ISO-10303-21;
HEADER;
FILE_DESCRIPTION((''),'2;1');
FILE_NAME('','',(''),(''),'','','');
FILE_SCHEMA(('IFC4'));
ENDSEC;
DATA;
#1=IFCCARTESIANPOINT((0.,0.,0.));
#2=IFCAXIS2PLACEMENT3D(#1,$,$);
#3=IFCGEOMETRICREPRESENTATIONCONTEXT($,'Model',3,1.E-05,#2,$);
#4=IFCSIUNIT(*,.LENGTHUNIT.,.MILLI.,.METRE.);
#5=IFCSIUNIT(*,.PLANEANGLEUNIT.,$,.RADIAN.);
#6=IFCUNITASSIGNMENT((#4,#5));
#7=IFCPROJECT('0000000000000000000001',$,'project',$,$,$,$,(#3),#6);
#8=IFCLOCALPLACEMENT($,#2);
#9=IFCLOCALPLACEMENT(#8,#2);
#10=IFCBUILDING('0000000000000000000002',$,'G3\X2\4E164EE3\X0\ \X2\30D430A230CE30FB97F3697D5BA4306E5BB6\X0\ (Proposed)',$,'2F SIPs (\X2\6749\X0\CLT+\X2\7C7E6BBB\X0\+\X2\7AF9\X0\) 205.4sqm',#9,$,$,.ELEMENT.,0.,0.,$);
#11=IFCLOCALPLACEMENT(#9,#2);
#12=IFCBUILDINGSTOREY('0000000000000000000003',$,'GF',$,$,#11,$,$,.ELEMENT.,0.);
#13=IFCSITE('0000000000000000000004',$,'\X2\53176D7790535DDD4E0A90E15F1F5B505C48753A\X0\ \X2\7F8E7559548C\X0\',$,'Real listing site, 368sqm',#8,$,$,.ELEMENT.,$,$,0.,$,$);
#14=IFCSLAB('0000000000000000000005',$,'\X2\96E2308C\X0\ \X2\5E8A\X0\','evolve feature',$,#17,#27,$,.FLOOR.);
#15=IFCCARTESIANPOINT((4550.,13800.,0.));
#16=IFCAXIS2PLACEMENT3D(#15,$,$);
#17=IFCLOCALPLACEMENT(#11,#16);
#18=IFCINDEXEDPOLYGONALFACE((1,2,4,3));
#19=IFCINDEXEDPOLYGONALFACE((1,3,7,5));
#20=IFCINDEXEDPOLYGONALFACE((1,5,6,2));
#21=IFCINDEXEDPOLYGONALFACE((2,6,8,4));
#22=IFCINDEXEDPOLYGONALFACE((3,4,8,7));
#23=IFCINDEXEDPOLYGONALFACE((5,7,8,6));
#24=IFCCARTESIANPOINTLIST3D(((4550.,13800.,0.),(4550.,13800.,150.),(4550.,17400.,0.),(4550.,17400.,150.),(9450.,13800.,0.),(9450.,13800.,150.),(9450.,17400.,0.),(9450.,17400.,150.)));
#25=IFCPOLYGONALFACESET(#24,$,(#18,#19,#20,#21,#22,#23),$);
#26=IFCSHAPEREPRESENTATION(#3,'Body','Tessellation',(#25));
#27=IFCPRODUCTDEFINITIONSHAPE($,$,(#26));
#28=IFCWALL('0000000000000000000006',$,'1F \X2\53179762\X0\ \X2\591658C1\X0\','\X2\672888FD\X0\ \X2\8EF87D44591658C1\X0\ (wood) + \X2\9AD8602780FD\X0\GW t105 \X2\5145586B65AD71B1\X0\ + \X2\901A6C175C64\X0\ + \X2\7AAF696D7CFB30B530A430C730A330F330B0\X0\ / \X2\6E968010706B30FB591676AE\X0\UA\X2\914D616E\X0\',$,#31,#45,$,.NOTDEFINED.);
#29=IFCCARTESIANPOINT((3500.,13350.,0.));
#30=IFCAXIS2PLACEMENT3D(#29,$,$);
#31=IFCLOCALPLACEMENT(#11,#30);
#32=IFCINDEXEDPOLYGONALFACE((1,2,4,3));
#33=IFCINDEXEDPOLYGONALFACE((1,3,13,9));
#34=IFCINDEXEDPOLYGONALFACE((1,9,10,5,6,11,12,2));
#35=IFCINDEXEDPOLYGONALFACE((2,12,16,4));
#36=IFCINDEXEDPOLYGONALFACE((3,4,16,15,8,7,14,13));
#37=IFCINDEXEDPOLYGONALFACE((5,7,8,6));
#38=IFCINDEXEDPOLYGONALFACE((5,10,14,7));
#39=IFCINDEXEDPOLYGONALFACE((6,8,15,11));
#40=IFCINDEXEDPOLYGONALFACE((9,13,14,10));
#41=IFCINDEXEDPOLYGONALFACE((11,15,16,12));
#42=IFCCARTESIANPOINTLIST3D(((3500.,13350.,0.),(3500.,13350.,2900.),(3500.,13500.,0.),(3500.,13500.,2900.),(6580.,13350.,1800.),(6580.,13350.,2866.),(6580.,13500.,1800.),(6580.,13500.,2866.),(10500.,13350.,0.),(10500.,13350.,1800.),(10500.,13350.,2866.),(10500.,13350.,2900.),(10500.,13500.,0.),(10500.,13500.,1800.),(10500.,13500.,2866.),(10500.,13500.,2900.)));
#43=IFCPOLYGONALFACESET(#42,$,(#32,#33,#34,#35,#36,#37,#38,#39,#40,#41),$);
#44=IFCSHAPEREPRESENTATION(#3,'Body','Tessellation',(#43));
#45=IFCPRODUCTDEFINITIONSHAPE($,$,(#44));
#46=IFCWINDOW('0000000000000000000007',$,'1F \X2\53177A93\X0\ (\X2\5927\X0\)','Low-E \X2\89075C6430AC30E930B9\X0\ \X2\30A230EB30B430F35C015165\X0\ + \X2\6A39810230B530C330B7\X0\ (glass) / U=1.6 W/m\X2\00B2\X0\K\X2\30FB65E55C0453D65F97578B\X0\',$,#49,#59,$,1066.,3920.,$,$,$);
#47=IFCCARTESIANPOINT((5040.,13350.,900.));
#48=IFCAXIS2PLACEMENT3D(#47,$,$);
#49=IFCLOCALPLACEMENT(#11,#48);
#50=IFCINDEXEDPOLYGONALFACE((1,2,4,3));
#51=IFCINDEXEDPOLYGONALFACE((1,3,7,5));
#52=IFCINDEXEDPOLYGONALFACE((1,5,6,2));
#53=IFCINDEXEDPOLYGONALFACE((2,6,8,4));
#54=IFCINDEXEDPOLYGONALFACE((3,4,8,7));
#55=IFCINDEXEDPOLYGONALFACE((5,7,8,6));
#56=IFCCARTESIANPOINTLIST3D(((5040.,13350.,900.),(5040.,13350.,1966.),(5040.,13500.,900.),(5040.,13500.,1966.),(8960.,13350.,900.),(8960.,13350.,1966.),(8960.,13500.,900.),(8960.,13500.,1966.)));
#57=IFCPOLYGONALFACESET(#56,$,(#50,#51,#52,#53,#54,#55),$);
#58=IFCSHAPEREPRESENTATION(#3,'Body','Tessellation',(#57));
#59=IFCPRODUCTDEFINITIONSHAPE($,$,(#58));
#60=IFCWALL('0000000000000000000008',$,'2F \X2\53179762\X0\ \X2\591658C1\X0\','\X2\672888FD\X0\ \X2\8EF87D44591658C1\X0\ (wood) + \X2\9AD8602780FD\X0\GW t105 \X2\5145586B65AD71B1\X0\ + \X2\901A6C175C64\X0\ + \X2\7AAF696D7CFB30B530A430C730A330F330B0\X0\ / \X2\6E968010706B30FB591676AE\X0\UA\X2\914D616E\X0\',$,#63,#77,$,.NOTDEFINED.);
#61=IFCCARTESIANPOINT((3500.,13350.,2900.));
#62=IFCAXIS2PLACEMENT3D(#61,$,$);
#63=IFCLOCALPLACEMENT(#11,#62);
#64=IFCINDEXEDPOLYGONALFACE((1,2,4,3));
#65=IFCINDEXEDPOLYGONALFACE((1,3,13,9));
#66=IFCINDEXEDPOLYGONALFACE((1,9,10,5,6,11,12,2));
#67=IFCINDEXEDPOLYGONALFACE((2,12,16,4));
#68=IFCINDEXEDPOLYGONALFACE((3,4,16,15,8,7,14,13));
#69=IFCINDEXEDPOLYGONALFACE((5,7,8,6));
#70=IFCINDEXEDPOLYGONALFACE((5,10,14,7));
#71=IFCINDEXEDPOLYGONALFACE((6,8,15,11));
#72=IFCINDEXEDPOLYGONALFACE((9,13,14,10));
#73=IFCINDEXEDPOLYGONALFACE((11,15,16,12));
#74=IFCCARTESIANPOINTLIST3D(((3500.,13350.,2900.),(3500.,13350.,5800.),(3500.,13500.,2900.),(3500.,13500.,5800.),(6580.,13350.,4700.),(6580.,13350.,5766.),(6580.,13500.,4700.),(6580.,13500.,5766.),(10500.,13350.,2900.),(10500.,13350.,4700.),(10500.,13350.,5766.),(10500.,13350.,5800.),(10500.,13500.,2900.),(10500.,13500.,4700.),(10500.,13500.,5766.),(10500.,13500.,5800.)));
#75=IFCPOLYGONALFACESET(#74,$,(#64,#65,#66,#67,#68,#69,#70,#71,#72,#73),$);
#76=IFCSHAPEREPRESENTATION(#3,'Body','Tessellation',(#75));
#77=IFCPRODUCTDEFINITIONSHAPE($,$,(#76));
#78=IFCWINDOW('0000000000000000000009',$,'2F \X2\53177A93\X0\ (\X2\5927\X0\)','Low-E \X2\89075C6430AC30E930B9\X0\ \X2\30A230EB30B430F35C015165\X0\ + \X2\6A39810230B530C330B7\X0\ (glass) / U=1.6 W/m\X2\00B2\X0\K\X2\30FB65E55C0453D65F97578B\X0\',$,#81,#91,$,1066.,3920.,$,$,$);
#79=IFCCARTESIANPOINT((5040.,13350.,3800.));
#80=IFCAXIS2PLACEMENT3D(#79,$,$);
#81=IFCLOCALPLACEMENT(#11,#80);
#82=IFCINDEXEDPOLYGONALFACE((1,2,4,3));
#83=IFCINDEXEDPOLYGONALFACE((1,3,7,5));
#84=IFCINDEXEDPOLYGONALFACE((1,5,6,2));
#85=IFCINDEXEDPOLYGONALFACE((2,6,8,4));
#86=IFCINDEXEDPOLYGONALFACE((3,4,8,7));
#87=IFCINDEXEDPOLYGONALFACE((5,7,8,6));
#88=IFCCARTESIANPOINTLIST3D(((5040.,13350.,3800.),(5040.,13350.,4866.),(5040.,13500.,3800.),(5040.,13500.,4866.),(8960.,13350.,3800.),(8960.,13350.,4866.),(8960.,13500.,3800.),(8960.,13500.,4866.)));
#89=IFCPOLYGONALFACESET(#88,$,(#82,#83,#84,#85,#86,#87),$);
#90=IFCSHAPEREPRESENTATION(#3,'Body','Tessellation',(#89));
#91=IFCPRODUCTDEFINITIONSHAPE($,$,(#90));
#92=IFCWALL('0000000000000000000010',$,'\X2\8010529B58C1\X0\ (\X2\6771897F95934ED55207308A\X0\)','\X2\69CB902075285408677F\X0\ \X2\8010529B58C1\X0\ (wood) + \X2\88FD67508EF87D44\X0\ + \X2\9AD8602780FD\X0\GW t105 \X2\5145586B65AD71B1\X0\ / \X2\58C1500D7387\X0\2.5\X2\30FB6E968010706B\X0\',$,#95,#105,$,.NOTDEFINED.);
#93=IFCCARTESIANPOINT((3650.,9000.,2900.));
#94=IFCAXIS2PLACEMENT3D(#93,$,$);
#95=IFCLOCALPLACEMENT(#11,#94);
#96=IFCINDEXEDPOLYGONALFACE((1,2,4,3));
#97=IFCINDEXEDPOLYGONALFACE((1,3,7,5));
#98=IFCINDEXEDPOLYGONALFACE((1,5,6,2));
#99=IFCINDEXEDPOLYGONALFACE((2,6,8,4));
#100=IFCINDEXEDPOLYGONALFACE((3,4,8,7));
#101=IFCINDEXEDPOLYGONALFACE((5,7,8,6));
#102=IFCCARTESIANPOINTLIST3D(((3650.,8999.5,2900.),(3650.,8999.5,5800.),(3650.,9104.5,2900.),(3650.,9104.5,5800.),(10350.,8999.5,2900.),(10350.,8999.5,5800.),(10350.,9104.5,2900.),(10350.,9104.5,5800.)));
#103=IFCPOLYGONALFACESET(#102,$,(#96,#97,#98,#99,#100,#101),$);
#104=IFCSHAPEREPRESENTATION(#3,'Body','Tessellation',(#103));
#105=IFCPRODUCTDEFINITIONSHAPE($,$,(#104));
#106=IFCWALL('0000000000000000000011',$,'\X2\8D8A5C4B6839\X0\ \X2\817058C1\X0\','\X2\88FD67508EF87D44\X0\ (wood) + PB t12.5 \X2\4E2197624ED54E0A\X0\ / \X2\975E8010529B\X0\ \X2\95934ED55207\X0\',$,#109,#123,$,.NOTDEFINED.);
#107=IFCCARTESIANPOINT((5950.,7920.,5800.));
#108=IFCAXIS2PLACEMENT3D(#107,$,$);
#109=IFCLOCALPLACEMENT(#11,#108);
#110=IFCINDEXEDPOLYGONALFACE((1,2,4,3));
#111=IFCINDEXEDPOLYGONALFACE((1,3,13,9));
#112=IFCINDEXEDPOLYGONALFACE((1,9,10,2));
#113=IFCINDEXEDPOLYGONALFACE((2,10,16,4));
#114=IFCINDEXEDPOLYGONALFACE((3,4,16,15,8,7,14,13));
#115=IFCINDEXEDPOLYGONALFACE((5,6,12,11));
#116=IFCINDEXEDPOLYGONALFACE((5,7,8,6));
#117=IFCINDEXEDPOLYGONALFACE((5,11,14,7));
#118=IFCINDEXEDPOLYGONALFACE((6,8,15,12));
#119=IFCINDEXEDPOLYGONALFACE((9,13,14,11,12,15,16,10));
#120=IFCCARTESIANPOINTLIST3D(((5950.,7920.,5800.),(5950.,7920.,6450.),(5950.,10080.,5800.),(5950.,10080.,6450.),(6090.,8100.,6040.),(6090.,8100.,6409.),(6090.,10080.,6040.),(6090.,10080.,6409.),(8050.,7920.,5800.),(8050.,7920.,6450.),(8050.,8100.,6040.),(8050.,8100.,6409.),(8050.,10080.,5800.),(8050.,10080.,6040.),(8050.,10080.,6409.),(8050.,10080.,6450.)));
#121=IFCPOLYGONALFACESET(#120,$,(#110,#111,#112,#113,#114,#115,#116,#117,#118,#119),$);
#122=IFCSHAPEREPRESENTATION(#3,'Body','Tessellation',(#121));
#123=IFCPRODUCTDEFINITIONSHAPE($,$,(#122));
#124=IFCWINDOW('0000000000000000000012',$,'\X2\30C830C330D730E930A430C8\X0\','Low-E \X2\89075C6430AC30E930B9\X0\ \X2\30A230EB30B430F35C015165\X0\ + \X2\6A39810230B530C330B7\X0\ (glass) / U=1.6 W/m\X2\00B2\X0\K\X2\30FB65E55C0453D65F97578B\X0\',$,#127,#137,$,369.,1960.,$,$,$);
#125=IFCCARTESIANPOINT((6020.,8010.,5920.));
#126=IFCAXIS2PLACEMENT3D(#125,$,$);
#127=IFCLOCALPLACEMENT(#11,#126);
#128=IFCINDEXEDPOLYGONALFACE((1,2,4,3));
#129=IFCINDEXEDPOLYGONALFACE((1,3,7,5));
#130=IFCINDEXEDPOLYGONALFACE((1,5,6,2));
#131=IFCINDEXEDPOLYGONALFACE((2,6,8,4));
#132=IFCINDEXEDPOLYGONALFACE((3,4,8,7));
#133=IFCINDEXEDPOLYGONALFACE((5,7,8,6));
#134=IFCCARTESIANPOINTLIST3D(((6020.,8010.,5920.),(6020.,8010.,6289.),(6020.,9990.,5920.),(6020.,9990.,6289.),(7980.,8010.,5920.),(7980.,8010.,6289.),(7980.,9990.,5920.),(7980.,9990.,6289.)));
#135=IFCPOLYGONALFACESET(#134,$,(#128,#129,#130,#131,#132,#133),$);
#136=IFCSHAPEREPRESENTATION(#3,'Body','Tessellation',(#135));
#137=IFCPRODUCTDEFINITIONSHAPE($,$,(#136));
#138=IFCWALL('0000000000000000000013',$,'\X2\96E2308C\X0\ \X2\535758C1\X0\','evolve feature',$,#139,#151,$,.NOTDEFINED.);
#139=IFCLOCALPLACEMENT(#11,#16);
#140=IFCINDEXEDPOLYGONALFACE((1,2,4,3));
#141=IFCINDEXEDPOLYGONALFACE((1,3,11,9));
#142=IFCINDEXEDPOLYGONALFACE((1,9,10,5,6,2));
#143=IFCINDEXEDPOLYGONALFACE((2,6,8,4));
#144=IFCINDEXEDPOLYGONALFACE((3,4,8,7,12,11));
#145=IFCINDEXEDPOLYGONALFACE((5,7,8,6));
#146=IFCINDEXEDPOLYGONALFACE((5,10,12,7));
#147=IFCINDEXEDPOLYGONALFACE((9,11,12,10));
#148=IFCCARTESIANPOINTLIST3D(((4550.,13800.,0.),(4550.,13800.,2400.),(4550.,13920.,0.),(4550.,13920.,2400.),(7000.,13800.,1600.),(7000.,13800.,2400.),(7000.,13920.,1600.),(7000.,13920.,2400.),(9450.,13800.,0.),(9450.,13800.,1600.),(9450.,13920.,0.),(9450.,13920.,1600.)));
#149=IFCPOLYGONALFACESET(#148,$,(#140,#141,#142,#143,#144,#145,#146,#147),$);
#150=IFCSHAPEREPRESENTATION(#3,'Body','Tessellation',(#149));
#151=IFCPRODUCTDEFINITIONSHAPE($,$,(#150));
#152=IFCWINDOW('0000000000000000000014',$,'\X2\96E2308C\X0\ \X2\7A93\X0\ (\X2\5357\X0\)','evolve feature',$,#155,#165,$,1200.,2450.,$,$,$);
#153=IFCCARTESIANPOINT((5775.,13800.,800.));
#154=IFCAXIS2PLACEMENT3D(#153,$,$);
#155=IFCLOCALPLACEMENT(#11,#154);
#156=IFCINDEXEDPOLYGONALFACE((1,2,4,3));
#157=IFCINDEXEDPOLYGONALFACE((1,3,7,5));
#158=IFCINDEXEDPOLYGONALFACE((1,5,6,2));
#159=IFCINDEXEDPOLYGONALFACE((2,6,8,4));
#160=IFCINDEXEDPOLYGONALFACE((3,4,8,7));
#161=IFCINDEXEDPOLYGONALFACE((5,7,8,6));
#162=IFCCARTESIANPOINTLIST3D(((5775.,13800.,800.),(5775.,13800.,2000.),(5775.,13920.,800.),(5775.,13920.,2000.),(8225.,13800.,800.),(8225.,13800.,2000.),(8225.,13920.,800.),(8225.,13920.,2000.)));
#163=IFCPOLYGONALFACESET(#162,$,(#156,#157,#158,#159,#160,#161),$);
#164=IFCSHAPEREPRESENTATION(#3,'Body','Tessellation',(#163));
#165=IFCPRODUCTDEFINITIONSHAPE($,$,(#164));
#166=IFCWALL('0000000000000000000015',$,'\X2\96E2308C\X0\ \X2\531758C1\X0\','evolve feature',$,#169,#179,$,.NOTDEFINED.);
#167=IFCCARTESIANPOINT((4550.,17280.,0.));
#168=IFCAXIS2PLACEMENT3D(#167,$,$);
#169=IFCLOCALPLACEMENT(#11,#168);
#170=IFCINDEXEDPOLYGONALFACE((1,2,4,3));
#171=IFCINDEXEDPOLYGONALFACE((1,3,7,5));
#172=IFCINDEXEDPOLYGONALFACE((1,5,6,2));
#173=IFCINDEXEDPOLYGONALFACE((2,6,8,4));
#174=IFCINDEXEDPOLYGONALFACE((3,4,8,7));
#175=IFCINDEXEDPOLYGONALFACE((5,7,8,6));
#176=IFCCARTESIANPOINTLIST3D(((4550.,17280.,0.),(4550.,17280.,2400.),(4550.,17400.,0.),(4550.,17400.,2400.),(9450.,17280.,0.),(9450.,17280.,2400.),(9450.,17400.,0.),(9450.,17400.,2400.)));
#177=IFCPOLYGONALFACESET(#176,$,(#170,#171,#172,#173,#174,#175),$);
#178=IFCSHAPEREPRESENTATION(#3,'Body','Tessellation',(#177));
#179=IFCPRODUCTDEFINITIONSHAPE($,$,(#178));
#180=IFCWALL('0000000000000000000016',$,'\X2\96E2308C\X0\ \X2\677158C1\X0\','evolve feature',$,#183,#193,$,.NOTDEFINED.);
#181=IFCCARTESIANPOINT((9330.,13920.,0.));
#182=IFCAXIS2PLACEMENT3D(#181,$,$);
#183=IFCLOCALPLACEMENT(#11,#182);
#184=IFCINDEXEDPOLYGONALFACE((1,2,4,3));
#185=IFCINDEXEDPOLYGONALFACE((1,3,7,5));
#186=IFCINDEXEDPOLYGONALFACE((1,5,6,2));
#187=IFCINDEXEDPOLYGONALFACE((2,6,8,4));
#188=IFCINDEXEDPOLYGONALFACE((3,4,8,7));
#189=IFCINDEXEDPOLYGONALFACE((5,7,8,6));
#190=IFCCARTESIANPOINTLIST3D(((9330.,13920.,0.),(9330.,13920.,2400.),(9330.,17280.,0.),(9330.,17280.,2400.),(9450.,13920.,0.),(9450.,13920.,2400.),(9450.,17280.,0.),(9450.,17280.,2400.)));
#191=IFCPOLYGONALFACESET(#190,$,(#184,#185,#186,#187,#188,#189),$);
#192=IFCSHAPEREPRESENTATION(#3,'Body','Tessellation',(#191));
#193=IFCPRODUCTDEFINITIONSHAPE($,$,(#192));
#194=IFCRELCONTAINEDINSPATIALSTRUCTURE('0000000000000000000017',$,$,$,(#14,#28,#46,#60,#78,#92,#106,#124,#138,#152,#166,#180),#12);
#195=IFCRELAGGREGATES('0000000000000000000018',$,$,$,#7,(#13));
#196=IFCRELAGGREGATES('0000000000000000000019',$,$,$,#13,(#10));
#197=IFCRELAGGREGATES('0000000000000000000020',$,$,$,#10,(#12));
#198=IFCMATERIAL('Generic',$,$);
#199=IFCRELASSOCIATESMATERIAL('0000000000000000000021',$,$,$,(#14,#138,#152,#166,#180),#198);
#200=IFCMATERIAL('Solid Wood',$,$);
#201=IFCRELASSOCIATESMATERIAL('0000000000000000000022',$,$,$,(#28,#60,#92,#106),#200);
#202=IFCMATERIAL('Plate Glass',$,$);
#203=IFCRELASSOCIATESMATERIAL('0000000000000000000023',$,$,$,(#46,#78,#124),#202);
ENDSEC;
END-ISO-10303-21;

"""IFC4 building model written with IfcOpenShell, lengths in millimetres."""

from ifc_helpers import new_model, si_unit, frame, frame_2d, origin, place, context, project, spatial, rectangle, extrude, material, element, fill, save


model = new_model("IFC4")

# Units and contexts
model_context = context("Model", 3, precision=1e-05, world=origin())
ifc_project = project(units=[si_unit("LENGTHUNIT", "METRE", prefix="MILLI"), si_unit("PLANEANGLEUNIT", "RADIAN")], contexts=[model_context])

# Site, building, storey
site_placement = place(None, origin())
site = spatial("IfcSite", under=ifc_project, at=site_placement, Name="北海道川上郡弟子屈町 美留和", ObjectType="Real listing site, 368sqm", CompositionType="ELEMENT", RefElevation=0.0)
building_placement = place(site_placement, origin())
building = spatial("IfcBuilding", under=site, at=building_placement, Name="G3世代 ピアノ・音楽室の家 (Proposed)", ObjectType="2F SIPs (杉CLT+籾殻+竹) 205.4sqm", CompositionType="ELEMENT", ElevationOfRefHeight=0.0, ElevationOfTerrain=0.0)
storey_placement = place(building_placement, origin())
storey = spatial("IfcBuildingStorey", under=building, at=storey_placement, Name="GF", CompositionType="ELEMENT", Elevation=0.0)

# Slab
ifc_material_1 = material(Name="Generic")
slab_placement = place(storey_placement, frame((4550.0, 13800.0, 0.0)))
element("IfcSlab", 1, at=slab_placement, inside=storey, material=ifc_material_1, Name="離れ 床", Description="evolve feature", PredefinedType="FLOOR", context=model_context, shape_type="SweptSolid", body=[
    extrude(rectangle(XDim=4900.0, YDim=3600.0, at=frame_2d((2450.0, 1800.0))), frame((4550.0, 13800.0, 0.0)), (0.0, 0.0, 1.0), 150.0),
])

# Wall, opening, window
ifc_material_2 = material(Name="Solid Wood")
wall_1_placement = place(storey_placement, frame((3500.0, 13350.0, 0.0)))
wall_1 = element("IfcWall", 2, at=wall_1_placement, inside=storey, material=ifc_material_2, Name="1F 北面 外壁", Description="木製 軸組外壁 (wood) + 高性能GW t105 充填断熱 + 通気層 + 窯業系サイディング / 準耐火・外皮UA配慮", PredefinedType="NOTDEFINED", context=model_context, shape_type="SweptSolid", body=[
    extrude(rectangle(XDim=7000.0, YDim=150.0, at=frame_2d((3500.0, 75.0))), frame((3500.0, 13350.0, 0.0)), (0.0, 0.0, 1.0), 2900.0),
])
opening_1_placement = place(storey_placement, frame((5040.0, 13350.0, 900.0)))
opening_1 = element("IfcOpeningElement", 3, at=opening_1_placement, cuts=wall_1, PredefinedType="NOTDEFINED", context=model_context, shape_type="SweptSolid", body=[
    extrude(rectangle(XDim=3920.0, YDim=150.0, at=frame_2d((1960.0, 75.0))), frame((5040.0, 13350.0, 900.0)), (0.0, 0.0, 1.0), 1066.0),
])
ifc_material_3 = material(Name="Plate Glass")
window_1_placement = place(storey_placement, frame((5040.0, 13350.0, 900.0)))
window_1 = element("IfcWindow", 4, at=window_1_placement, inside=storey, material=ifc_material_3, Name="1F 北窓 (大)", Description="Low-E 複層ガラス アルゴン封入 + 樹脂サッシ (glass) / U=1.6 W/m²K・日射取得型", OverallHeight=1066.0, OverallWidth=3920.0, context=model_context, shape_type="SweptSolid", body=[
    extrude(rectangle(XDim=3920.0, YDim=150.0, at=frame_2d((1960.0, 75.0))), frame((5040.0, 13350.0, 900.0)), (0.0, 0.0, 1.0), 1066.0),
])
fill(opening_1, window_1)

# Wall, opening, window
wall_2_placement = place(storey_placement, frame((3500.0, 13350.0, 2900.0)))
wall_2 = element("IfcWall", 5, at=wall_2_placement, inside=storey, material=ifc_material_2, Name="2F 北面 外壁", Description="木製 軸組外壁 (wood) + 高性能GW t105 充填断熱 + 通気層 + 窯業系サイディング / 準耐火・外皮UA配慮", PredefinedType="NOTDEFINED", context=model_context, shape_type="SweptSolid", body=[
    extrude(rectangle(XDim=7000.0, YDim=150.0, at=frame_2d((3500.0, 75.0))), frame((3500.0, 13350.0, 2900.0)), (0.0, 0.0, 1.0), 2900.0),
])
opening_2_placement = place(storey_placement, frame((5040.0, 13350.0, 3800.0)))
opening_2 = element("IfcOpeningElement", 6, at=opening_2_placement, cuts=wall_2, PredefinedType="NOTDEFINED", context=model_context, shape_type="SweptSolid", body=[
    extrude(rectangle(XDim=3920.0, YDim=150.0, at=frame_2d((1960.0, 75.0))), frame((5040.0, 13350.0, 3800.0)), (0.0, 0.0, 1.0), 1066.0),
])
window_2_placement = place(storey_placement, frame((5040.0, 13350.0, 3800.0)))
window_2 = element("IfcWindow", 7, at=window_2_placement, inside=storey, material=ifc_material_3, Name="2F 北窓 (大)", Description="Low-E 複層ガラス アルゴン封入 + 樹脂サッシ (glass) / U=1.6 W/m²K・日射取得型", OverallHeight=1066.0, OverallWidth=3920.0, context=model_context, shape_type="SweptSolid", body=[
    extrude(rectangle(XDim=3920.0, YDim=150.0, at=frame_2d((1960.0, 75.0))), frame((5040.0, 13350.0, 3800.0)), (0.0, 0.0, 1.0), 1066.0),
])
fill(opening_2, window_2)

# Wall
wall_3_placement = place(storey_placement, frame((3650.0, 9000.0, 2900.0)))
element("IfcWall", 8, at=wall_3_placement, inside=storey, material=ifc_material_2, Name="耐力壁 (東西間仕切り)", Description="構造用合板 耐力壁 (wood) + 製材軸組 + 高性能GW t105 充填断熱 / 壁倍率2.5・準耐火", PredefinedType="NOTDEFINED", context=model_context, shape_type="SweptSolid", body=[
    extrude(rectangle(XDim=6700.0, YDim=105.0, at=frame_2d((3350.0, 52.0))), frame((3650.0, 9000.0, 2900.0)), (0.0, 0.0, 1.0), 2900.0),
])

# Walls, openings, windows
wall_4_placement = place(storey_placement, frame((5950.0, 7920.0, 5800.0)))
wall_4 = element("IfcWall", 9, at=wall_4_placement, inside=storey, material=ifc_material_2, Name="越屋根 腰壁", Description="製材軸組 (wood) + PB t12.5 両面仕上 / 非耐力 間仕切", PredefinedType="NOTDEFINED", context=model_context, shape_type="SweptSolid", body=[
    extrude(rectangle(XDim=2100.0, YDim=2160.0, at=frame_2d((1050.0, 1080.0))), frame((5950.0, 7920.0, 5800.0)), (0.0, 0.0, 1.0), 650.0),
])
opening_3_placement = place(storey_placement, frame((6020.0, 8010.0, 5920.0)))
opening_3 = element("IfcOpeningElement", 10, at=opening_3_placement, cuts=wall_4, PredefinedType="NOTDEFINED", context=model_context, shape_type="SweptSolid", body=[
    extrude(rectangle(XDim=1960.0, YDim=1980.0, at=frame_2d((980.0, 990.0))), frame((6020.0, 8010.0, 5920.0)), (0.0, 0.0, 1.0), 369.0),
])
window_3_placement = place(storey_placement, frame((6020.0, 8010.0, 5920.0)))
window_3 = element("IfcWindow", 11, at=window_3_placement, inside=storey, material=ifc_material_3, Name="トップライト", Description="Low-E 複層ガラス アルゴン封入 + 樹脂サッシ (glass) / U=1.6 W/m²K・日射取得型", OverallHeight=369.0, OverallWidth=1960.0, context=model_context, shape_type="SweptSolid", body=[
    extrude(rectangle(XDim=1960.0, YDim=1980.0, at=frame_2d((980.0, 990.0))), frame((6020.0, 8010.0, 5920.0)), (0.0, 0.0, 1.0), 369.0),
])
fill(opening_3, window_3)
wall_5_placement = place(storey_placement, frame((4550.0, 13800.0, 0.0)))
wall_5 = element("IfcWall", 12, at=wall_5_placement, inside=storey, material=ifc_material_1, Name="離れ 南壁", Description="evolve feature", PredefinedType="NOTDEFINED", context=model_context, shape_type="SweptSolid", body=[
    extrude(rectangle(XDim=4900.0, YDim=120.0, at=frame_2d((2450.0, 60.0))), frame((4550.0, 13800.0, 0.0)), (0.0, 0.0, 1.0), 2400.0),
])
opening_4_placement = place(storey_placement, frame((5775.0, 13800.0, 800.0)))
opening_4 = element("IfcOpeningElement", 13, at=opening_4_placement, cuts=wall_5, PredefinedType="NOTDEFINED", context=model_context, shape_type="SweptSolid", body=[
    extrude(rectangle(XDim=2450.0, YDim=120.0, at=frame_2d((1225.0, 60.0))), frame((5775.0, 13800.0, 800.0)), (0.0, 0.0, 1.0), 1200.0),
])
window_4_placement = place(storey_placement, frame((5775.0, 13800.0, 800.0)))
window_4 = element("IfcWindow", 14, at=window_4_placement, inside=storey, material=ifc_material_1, Name="離れ 窓 (南)", Description="evolve feature", OverallHeight=1200.0, OverallWidth=2450.0, context=model_context, shape_type="SweptSolid", body=[
    extrude(rectangle(XDim=2450.0, YDim=120.0, at=frame_2d((1225.0, 60.0))), frame((5775.0, 13800.0, 800.0)), (0.0, 0.0, 1.0), 1200.0),
])
fill(opening_4, window_4)

# Walls
wall_6_placement = place(storey_placement, frame((4550.0, 17280.0, 0.0)))
element("IfcWall", 15, at=wall_6_placement, inside=storey, material=ifc_material_1, Name="離れ 北壁", Description="evolve feature", PredefinedType="NOTDEFINED", context=model_context, shape_type="SweptSolid", body=[
    extrude(rectangle(XDim=4900.0, YDim=120.0, at=frame_2d((2450.0, 60.0))), frame((4550.0, 17280.0, 0.0)), (0.0, 0.0, 1.0), 2400.0),
])
wall_7_placement = place(storey_placement, frame((9330.0, 13920.0, 0.0)))
element("IfcWall", 16, at=wall_7_placement, inside=storey, material=ifc_material_1, Name="離れ 東壁", Description="evolve feature", PredefinedType="NOTDEFINED", context=model_context, shape_type="SweptSolid", body=[
    extrude(rectangle(XDim=120.0, YDim=3360.0, at=frame_2d((60.0, 1680.0))), frame((9330.0, 13920.0, 0.0)), (0.0, 0.0, 1.0), 2400.0),
])

save(model, "model.ifc")
